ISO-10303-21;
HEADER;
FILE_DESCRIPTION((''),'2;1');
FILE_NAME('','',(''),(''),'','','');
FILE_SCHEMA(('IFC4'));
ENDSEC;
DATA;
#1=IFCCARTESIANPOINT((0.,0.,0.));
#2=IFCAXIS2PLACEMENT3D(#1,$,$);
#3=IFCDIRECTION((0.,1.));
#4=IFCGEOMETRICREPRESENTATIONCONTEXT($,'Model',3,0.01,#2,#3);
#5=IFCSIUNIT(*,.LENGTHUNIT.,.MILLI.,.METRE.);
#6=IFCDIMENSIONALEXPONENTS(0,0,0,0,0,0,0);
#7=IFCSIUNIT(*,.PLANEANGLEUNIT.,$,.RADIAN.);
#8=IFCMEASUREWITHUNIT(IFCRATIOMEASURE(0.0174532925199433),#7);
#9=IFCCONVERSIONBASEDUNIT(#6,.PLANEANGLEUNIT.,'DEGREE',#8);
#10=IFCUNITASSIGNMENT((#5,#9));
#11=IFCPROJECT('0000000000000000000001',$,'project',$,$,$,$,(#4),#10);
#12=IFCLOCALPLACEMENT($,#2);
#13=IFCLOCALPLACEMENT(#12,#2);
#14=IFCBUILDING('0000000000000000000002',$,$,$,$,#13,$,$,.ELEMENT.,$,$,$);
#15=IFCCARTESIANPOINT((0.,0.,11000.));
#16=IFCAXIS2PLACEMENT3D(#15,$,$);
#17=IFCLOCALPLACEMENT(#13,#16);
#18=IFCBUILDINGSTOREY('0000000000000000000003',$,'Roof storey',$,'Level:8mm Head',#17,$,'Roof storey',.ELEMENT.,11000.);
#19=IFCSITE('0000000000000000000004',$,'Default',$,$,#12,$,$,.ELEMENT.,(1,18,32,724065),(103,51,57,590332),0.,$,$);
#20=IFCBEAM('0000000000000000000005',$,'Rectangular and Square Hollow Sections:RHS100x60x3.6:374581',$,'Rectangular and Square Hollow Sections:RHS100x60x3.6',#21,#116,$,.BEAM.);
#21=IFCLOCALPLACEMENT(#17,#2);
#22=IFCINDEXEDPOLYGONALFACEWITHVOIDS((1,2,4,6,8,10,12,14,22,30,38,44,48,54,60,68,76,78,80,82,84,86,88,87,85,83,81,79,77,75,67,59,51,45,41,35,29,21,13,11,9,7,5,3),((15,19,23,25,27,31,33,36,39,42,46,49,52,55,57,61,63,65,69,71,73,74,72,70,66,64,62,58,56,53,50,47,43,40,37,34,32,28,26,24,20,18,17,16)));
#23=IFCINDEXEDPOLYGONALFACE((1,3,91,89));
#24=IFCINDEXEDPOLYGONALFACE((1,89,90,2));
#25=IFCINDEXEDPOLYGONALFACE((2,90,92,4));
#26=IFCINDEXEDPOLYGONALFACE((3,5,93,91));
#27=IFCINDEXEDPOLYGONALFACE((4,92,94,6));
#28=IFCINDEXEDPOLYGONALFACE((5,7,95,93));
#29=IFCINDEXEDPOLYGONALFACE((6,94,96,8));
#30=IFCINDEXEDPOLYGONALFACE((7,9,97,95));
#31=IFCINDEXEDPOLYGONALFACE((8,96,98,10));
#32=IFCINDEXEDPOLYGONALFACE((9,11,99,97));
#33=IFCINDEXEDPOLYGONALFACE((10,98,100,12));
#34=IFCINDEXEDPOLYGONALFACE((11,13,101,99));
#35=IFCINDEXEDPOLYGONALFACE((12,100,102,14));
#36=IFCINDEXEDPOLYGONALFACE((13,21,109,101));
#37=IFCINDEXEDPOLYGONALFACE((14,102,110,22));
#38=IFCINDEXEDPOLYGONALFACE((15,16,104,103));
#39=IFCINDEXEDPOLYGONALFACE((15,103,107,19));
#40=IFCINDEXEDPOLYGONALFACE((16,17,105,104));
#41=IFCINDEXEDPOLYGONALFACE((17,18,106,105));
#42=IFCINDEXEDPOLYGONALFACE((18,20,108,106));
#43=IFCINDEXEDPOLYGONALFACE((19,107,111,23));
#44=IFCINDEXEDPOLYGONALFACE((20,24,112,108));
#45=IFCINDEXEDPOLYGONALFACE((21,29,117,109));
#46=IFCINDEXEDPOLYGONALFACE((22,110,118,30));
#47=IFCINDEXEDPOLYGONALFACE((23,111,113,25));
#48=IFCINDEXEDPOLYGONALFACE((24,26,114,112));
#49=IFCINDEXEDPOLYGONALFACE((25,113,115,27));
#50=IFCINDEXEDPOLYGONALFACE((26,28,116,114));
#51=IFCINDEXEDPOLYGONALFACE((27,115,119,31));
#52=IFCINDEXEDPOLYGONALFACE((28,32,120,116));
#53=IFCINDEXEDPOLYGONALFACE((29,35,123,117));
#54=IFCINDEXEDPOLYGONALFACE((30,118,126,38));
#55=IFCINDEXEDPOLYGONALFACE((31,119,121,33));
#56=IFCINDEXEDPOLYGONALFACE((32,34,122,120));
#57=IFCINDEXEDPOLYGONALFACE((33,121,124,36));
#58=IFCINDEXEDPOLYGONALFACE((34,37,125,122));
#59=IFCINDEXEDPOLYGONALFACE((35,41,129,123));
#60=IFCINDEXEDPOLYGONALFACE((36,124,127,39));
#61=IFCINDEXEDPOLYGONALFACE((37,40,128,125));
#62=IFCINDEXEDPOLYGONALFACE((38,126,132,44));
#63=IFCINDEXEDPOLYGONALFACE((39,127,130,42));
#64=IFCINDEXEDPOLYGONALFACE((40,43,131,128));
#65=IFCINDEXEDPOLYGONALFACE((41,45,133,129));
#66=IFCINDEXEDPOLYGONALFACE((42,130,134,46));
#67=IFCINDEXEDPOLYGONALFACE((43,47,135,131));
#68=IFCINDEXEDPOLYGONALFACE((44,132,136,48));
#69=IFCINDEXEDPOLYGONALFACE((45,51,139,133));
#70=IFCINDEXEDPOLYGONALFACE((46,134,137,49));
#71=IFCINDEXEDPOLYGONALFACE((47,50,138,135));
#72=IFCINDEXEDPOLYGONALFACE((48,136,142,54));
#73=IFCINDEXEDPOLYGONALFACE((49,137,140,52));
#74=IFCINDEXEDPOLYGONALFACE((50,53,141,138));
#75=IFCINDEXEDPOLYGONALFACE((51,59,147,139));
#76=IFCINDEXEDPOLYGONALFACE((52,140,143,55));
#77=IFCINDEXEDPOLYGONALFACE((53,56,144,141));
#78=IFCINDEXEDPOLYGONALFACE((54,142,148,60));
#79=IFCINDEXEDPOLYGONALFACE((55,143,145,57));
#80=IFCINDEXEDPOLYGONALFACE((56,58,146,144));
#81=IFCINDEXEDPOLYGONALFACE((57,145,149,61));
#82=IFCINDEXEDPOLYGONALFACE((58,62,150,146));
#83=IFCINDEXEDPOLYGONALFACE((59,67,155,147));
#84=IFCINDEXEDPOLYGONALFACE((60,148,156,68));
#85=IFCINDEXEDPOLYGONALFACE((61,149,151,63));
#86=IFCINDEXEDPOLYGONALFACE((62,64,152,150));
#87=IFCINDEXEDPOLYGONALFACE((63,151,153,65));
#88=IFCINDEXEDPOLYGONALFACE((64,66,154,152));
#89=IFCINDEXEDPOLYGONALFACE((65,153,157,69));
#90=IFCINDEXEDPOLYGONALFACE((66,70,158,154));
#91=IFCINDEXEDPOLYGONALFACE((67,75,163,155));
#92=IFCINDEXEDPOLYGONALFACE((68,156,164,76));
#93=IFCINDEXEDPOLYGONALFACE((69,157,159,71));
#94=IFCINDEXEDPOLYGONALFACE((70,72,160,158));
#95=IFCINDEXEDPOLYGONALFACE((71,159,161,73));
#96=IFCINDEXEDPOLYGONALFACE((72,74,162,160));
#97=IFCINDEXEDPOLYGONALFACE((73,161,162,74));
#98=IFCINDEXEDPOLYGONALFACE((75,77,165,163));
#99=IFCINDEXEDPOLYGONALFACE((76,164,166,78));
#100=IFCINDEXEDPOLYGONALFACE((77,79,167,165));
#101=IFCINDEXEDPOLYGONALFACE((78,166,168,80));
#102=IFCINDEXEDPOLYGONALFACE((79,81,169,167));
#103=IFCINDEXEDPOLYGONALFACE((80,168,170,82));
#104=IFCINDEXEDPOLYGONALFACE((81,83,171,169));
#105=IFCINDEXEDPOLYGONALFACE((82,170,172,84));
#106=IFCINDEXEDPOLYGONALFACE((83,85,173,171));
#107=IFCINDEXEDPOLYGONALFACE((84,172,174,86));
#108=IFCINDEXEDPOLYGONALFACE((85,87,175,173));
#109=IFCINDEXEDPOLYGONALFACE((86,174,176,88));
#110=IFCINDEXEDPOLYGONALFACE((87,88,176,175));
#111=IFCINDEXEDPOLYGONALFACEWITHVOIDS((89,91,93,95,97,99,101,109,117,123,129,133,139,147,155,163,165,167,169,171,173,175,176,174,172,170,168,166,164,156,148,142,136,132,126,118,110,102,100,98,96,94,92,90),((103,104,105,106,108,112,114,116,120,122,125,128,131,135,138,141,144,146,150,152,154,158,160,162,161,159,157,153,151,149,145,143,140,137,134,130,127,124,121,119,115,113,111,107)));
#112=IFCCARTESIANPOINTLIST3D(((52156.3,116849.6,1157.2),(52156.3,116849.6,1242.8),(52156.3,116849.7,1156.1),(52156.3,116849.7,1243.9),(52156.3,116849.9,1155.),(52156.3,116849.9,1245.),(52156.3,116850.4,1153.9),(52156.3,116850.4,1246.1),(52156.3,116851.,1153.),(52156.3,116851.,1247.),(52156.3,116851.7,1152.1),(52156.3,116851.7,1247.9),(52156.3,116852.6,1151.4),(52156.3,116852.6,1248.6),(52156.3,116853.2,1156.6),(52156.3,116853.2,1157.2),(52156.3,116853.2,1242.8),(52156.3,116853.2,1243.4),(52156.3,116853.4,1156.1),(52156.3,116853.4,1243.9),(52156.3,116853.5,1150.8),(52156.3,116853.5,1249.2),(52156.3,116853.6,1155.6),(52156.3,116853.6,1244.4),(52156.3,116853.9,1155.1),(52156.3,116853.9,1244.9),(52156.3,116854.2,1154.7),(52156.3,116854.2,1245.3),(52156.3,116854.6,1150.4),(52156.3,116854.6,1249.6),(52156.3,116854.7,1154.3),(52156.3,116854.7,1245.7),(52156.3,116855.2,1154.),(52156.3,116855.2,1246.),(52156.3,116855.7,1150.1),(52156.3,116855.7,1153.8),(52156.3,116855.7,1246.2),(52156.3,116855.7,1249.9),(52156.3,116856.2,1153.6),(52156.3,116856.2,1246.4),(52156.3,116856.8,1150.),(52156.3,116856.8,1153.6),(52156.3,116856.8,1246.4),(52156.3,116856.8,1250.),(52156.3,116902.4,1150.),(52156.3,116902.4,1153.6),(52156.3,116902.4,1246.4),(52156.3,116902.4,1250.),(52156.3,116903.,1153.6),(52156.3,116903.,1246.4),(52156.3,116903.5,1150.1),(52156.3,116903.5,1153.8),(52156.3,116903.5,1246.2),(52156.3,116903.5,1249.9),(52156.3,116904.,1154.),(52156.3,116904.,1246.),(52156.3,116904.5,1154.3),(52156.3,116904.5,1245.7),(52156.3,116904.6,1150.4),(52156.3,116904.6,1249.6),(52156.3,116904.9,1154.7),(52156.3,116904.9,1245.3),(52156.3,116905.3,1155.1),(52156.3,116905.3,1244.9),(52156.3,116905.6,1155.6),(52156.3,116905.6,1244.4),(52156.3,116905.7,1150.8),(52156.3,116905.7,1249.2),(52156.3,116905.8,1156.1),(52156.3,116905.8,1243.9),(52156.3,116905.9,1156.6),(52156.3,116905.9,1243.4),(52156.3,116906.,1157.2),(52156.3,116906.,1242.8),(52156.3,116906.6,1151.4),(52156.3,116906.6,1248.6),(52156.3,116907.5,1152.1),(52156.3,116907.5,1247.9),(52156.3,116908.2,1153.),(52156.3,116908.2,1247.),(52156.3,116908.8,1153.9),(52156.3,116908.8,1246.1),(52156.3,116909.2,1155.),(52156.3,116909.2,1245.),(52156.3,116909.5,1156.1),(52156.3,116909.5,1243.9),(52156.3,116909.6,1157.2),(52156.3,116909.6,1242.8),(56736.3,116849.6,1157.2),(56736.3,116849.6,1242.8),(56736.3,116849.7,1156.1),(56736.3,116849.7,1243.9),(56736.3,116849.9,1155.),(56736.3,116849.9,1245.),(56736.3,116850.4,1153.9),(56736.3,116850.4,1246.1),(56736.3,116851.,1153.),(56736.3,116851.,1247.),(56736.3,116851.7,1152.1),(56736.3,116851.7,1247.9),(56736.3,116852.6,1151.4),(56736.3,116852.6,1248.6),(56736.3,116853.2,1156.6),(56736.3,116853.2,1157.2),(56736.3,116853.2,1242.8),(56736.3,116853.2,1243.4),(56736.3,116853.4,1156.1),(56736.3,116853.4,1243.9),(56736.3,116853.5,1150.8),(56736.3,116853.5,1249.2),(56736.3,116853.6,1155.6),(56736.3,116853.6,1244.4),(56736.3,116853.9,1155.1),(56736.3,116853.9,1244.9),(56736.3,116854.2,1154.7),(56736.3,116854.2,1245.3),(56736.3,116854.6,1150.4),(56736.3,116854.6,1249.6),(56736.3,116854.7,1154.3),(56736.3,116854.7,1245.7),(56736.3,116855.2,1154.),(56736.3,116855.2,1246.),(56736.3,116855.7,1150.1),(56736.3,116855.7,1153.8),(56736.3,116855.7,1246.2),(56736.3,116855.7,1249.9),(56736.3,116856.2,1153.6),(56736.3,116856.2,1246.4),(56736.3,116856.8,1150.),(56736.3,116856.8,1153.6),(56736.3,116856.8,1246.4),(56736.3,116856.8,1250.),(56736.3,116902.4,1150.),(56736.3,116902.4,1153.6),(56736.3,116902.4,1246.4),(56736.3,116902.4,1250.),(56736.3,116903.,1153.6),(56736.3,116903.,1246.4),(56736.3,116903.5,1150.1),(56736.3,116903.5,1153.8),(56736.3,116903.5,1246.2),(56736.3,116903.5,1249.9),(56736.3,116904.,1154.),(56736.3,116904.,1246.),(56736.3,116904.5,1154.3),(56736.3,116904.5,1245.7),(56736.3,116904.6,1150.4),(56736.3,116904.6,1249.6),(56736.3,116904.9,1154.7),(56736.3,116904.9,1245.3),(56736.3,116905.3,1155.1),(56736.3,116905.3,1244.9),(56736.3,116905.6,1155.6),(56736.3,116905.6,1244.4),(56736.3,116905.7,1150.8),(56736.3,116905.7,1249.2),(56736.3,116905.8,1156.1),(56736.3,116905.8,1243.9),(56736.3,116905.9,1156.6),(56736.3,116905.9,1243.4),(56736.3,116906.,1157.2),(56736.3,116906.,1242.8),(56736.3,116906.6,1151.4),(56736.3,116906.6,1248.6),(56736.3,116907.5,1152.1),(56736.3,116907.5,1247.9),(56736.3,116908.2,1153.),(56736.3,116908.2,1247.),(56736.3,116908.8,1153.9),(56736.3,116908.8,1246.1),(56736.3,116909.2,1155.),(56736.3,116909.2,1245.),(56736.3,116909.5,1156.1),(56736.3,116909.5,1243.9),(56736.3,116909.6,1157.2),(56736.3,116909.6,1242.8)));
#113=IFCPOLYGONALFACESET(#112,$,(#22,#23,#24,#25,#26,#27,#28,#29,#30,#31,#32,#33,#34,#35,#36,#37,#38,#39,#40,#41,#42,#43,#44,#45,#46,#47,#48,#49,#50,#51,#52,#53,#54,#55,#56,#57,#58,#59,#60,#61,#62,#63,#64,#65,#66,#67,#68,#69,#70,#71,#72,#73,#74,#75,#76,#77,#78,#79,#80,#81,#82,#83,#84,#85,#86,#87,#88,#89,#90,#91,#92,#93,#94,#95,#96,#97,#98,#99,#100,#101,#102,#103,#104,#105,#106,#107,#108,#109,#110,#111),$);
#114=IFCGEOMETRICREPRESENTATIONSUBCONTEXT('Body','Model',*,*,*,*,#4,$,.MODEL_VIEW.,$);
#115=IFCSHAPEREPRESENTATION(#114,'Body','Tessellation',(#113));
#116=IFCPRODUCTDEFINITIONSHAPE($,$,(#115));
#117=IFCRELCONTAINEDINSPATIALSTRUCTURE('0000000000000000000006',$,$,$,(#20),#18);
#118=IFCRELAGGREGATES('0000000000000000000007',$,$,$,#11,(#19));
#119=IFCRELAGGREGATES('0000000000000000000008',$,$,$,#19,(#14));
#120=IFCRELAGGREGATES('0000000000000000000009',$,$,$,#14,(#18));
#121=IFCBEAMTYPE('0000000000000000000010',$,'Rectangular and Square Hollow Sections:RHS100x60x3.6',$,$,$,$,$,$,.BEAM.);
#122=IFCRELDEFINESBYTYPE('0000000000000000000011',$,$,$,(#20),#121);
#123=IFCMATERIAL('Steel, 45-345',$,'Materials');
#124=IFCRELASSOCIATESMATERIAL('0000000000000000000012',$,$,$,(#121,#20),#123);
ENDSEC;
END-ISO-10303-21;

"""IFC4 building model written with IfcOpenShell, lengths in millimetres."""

from ifc_helpers import new_model, entity, si_unit, converted_unit, direction, frame, origin, place, context, subcontext, project, spatial, indexed_curve, outline, extrude, source, transform, mapped, material, type_object, type_shapes, element, save


model = new_model("IFC4")

# Units and contexts
model_context = context("Model", 3, precision=0.01, world=origin(), true_north=direction((0.0, 1.0)))
body_context = subcontext(model_context, "Body", "Model", "MODEL_VIEW")
ifc_project = project(units=[si_unit("LENGTHUNIT", "METRE", prefix="MILLI"), converted_unit("PLANEANGLEUNIT", "DEGREE", entity("IfcRatioMeasure", 0.0174532925199433), si_unit("PLANEANGLEUNIT", "RADIAN"), dimensions=[0, 0, 0, 0, 0, 0, 0])], contexts=[model_context])

# Site, building, storey
site_placement = place(None, origin())
site = spatial("IfcSite", under=ifc_project, at=site_placement, Name="Default", CompositionType="ELEMENT", RefLatitude=(1, 18, 32, 724065), RefLongitude=(103, 51, 57, 590332), RefElevation=0.0)
building_placement = place(site_placement, origin())
building = spatial("IfcBuilding", under=site, at=building_placement, CompositionType="ELEMENT")
storey_placement = place(building_placement, frame((0.0, 0.0, 11000.0)))
storey = spatial("IfcBuildingStorey", under=building, at=storey_placement, Name="Roof storey", ObjectType="Level:8mm Head", LongName="Roof storey", CompositionType="ELEMENT", Elevation=11000.0)

# Shared definitions
ifc_material = material(Name="Steel, 45-345", Category="Materials")

# Beam
beam_type_1 = type_object("IfcBeamType", Name="Rectangular and Square Hollow Sections:RHS100x60x3.6", PredefinedType="BEAM", material=ifc_material)
shared_shape_1 = source(origin(), body_context, "Body", "SweptSolid", [
    extrude(outline(indexed_curve([(-30.0, -42.8), (-29.9, -43.9), (-29.6, -45.0), (-29.2, -46.1), (-28.6, -47.0), (-27.9, -47.9), (-27.0, -48.6), (-26.1, -49.2), (-25.0, -49.6), (-23.9, -49.9), (-22.8, -50.0), (22.8, -50.0), (23.9, -49.9), (25.0, -49.6), (26.1, -49.2), (27.0, -48.6), (27.9, -47.9), (28.6, -47.0), (29.2, -46.1), (29.6, -45.0), (29.9, -43.9), (30.0, -42.8), (30.0, 42.8), (29.9, 43.9), (29.6, 45.0), (29.2, 46.1), (28.6, 47.0), (27.9, 47.9), (27.0, 48.6), (26.1, 49.2), (25.0, 49.6), (23.9, 49.9), (22.8, 50.0), (-22.8, 50.0), (-23.9, 49.9), (-25.0, 49.6), (-26.1, 49.2), (-27.0, 48.6), (-27.9, 47.9), (-28.6, 47.0), (-29.2, 46.1), (-29.6, 45.0), (-29.9, 43.9), (-30.0, 42.8), (-30.0, -42.8)], self_intersect=False), holes=[indexed_curve([(22.8, -46.4), (-22.8, -46.4), (-23.4, -46.4), (-23.9, -46.2), (-24.4, -46.0), (-24.9, -45.7), (-25.3, -45.3), (-25.7, -44.9), (-26.0, -44.4), (-26.2, -43.9), (-26.4, -43.4), (-26.4, -42.8), (-26.4, 42.8), (-26.4, 43.4), (-26.2, 43.9), (-26.0, 44.4), (-25.7, 44.9), (-25.3, 45.3), (-24.9, 45.7), (-24.4, 46.0), (-23.9, 46.2), (-23.4, 46.4), (-22.8, 46.4), (22.8, 46.4), (23.4, 46.4), (23.9, 46.2), (24.4, 46.0), (24.9, 45.7), (25.3, 45.3), (25.7, 44.9), (26.0, 44.4), (26.2, 43.9), (26.4, 43.4), (26.4, 42.8), (26.4, -42.8), (26.4, -43.4), (26.2, -43.9), (26.0, -44.4), (25.7, -44.9), (25.3, -45.3), (24.9, -45.7), (24.4, -46.0), (23.9, -46.2), (23.4, -46.4), (22.8, -46.4)], self_intersect=False)]), frame((-2322.0, 0.0, 0.0), z_axis=(1.0, 0.0, 0.0), x_axis=(0.0, -1.0, 0.0)), (0.0, 0.0, 1.0), 4580.0),
])
type_shapes(beam_type_1, [shared_shape_1])
beam_1_placement = place(storey_placement, frame((54414.3, 116879.6, 1200.0), z_axis=(0.0, 0.0, 1.0), x_axis=(-1.0, 0.0, 0.0)))
element("IfcBeam", 1, at=beam_1_placement, inside=storey, type_object=beam_type_1, material=ifc_material, Name="Rectangular and Square Hollow Sections:RHS100x60x3.6:374581", ObjectType="Rectangular and Square Hollow Sections:RHS100x60x3.6", PredefinedType="BEAM", context=body_context, shape_type="MappedRepresentation", body=[
    mapped(shared_shape_1, transform((0.0, 0.0, 0.0), scale=1.0)),
])

save(model, "model.ifc")
